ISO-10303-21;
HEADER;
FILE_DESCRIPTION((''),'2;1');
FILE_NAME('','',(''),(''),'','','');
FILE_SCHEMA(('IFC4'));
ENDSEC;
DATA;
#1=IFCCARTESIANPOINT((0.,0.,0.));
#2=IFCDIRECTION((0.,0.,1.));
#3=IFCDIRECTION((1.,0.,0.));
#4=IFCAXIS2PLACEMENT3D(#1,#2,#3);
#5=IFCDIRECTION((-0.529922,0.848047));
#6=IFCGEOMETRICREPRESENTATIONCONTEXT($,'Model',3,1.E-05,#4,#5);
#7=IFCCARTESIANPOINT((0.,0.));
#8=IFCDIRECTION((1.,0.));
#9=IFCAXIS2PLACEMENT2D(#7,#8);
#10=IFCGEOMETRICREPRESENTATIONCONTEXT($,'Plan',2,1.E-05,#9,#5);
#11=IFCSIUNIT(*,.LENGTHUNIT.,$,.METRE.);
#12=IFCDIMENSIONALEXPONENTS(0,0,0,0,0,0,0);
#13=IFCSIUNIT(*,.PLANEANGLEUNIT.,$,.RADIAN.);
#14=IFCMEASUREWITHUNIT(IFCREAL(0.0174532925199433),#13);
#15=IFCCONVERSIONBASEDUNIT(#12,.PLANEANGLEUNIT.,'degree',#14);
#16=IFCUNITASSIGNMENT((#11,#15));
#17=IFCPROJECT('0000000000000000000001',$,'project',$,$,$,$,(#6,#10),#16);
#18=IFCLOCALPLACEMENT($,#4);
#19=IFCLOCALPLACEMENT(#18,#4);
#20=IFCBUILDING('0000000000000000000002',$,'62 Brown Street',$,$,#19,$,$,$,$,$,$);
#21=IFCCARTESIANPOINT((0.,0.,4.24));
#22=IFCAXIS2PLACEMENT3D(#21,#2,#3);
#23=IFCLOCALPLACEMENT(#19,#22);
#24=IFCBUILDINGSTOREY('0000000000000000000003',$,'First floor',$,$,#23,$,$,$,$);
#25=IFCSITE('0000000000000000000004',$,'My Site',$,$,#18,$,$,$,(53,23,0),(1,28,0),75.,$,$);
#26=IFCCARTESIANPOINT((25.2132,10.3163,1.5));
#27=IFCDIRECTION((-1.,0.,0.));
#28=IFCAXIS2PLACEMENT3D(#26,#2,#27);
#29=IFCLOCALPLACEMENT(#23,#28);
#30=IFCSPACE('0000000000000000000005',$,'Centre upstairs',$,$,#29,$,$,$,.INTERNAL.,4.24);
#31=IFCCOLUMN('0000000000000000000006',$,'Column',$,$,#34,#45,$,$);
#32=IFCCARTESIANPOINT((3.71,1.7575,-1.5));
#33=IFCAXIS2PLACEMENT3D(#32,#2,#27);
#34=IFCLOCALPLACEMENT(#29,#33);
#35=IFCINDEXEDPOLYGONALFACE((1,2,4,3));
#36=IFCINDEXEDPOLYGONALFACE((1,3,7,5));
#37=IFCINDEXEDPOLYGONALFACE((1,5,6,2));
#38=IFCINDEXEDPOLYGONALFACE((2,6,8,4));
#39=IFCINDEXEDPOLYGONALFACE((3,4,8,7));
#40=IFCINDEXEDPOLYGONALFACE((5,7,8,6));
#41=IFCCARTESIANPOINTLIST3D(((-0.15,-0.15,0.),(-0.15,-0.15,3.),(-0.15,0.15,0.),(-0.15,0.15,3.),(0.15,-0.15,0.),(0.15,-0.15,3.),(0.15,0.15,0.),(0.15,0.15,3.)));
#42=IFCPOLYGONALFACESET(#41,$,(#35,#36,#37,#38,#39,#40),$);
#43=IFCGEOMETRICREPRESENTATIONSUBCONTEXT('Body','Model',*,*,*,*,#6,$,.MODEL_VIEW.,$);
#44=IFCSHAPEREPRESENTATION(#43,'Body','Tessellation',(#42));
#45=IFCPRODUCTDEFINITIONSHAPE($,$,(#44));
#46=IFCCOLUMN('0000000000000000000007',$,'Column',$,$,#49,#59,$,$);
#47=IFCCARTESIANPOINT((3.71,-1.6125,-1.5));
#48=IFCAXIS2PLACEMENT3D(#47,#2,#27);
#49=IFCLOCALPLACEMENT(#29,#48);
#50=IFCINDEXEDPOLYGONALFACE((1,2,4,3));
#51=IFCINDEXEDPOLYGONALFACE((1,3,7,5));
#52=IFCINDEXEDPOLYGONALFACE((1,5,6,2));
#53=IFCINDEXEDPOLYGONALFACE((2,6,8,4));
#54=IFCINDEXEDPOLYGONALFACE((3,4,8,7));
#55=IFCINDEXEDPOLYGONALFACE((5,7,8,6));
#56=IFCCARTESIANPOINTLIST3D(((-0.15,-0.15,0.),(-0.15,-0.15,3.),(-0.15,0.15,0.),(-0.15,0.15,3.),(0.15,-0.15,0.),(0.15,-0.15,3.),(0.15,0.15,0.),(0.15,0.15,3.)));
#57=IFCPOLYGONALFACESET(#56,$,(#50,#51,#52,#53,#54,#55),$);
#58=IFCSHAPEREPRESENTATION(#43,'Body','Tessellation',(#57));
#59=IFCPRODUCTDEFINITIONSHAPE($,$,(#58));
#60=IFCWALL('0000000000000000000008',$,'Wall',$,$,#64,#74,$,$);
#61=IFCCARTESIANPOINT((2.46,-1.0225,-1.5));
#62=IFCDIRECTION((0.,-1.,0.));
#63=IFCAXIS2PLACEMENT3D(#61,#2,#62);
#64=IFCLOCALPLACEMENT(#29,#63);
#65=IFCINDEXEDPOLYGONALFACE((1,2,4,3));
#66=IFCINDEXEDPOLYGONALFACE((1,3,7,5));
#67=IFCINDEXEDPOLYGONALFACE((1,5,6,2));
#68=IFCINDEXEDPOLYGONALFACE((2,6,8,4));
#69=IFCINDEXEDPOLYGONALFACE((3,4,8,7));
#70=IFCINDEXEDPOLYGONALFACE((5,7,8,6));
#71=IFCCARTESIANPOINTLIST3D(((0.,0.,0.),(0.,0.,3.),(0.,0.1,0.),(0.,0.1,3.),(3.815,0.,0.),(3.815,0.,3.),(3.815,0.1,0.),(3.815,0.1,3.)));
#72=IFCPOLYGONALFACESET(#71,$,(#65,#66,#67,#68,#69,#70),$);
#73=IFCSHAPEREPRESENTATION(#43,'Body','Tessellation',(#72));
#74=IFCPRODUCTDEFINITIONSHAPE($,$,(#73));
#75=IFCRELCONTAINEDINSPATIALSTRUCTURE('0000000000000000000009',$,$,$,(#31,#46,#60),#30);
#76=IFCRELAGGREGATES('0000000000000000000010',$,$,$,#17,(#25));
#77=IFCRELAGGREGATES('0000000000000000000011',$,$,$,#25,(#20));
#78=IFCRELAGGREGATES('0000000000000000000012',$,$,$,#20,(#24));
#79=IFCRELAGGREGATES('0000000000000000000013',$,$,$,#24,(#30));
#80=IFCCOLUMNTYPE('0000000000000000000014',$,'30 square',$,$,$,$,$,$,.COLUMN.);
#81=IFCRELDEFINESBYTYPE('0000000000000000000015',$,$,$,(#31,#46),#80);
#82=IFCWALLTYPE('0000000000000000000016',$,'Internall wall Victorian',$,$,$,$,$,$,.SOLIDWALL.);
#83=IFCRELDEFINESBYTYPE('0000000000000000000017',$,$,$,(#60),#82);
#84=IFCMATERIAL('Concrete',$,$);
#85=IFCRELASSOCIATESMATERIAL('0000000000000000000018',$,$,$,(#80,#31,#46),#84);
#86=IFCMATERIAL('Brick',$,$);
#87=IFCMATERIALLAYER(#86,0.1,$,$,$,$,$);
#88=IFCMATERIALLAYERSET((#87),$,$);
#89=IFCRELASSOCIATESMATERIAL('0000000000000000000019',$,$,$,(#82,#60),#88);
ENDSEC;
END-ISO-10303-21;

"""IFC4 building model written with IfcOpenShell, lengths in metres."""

from ifc_helpers import new_model, entity, si_unit, converted_unit, direction, frame, origin_with_axes, origin_2d_with_axis, place, context, subcontext, project, spatial, indexed_curve, rectangle, outline, extrude, material, layer, layer_set, layer_usage, material_profile, profile_set, profile_usage, type_object, element, save


model = new_model("IFC4")

# Units and contexts
model_context = context("Model", 3, precision=1e-05, world=origin_with_axes(), true_north=direction((-0.529922, 0.848047)))
plan_context = context("Plan", 2, precision=1e-05, world=origin_2d_with_axis(), true_north=direction((-0.529922, 0.848047)))
body_context = subcontext(model_context, "Body", "Model", "MODEL_VIEW")
ifc_project = project(units=[si_unit("LENGTHUNIT", "METRE"), converted_unit("PLANEANGLEUNIT", "degree", entity("IfcReal", 0.0174532925199433), si_unit("PLANEANGLEUNIT", "RADIAN"), dimensions=[0, 0, 0, 0, 0, 0, 0])], contexts=[model_context, plan_context])

# Site, building, storey, space
site_placement = place(None, origin_with_axes())
site = spatial("IfcSite", under=ifc_project, at=site_placement, Name="My Site", RefLatitude=(53, 23, 0), RefLongitude=(1, 28, 0), RefElevation=75.0)
building_placement = place(site_placement, origin_with_axes())
building = spatial("IfcBuilding", under=site, at=building_placement, Name="62 Brown Street")
storey_placement = place(building_placement, frame((0.0, 0.0, 4.24), z_axis=(0.0, 0.0, 1.0), x_axis=(1.0, 0.0, 0.0)))
storey = spatial("IfcBuildingStorey", under=building, at=storey_placement, Name="First floor")
space_1_placement = place(storey_placement, frame((25.2132, 10.3163, 1.5), z_axis=(0.0, 0.0, 1.0), x_axis=(-1.0, 0.0, 0.0)))
space_1 = spatial("IfcSpace", under=storey, at=space_1_placement, Name="Centre upstairs", PredefinedType="INTERNAL", ElevationWithFlooring=4.24)

# Columns
ifc_material_1 = material(Name="Concrete")
ifc_material_profile_1 = material_profile(ifc_material_1, rectangle(XDim=0.3, YDim=0.3))
ifc_profile_set_1 = profile_set([ifc_material_profile_1])
ifc_profile_usage_1 = profile_usage(ifc_profile_set_1, cardinal=5)
column_type = type_object("IfcColumnType", Name="30 square", PredefinedType="COLUMN", material=ifc_profile_set_1)
column_1_placement = place(space_1_placement, frame((3.71, 1.7575, -1.5), z_axis=(0.0, 0.0, 1.0), x_axis=(-1.0, 0.0, 0.0)))
element("IfcColumn", 1, at=column_1_placement, inside=space_1, type_object=column_type, material=ifc_profile_usage_1, Name="Column", context=body_context, shape_type="SweptSolid", body=[
    extrude(rectangle(XDim=0.3, YDim=0.3), origin_with_axes(), (0.0, 0.0, 1.0), 3.0),
])
ifc_profile_usage_2 = profile_usage(ifc_profile_set_1, cardinal=5)
column_2_placement = place(space_1_placement, frame((3.71, -1.6125, -1.5), z_axis=(0.0, 0.0, 1.0), x_axis=(-1.0, 0.0, 0.0)))
element("IfcColumn", 2, at=column_2_placement, inside=space_1, type_object=column_type, material=ifc_profile_usage_2, Name="Column", context=body_context, shape_type="SweptSolid", body=[
    extrude(rectangle(XDim=0.3, YDim=0.3), origin_with_axes(), (0.0, 0.0, 1.0), 3.0),
])

# Wall
ifc_material_2 = material(Name="Brick")
ifc_layer_1 = layer(ifc_material_2, 0.1)
ifc_layer_set_1 = layer_set([ifc_layer_1])
ifc_layer_usage_1 = layer_usage(ifc_layer_set_1, "AXIS2", "POSITIVE", 0.0)
wall_type_1 = type_object("IfcWallType", Name="Internall wall Victorian", PredefinedType="SOLIDWALL", material=ifc_layer_set_1)
wall_1_placement = place(space_1_placement, frame((2.46, -1.0225, -1.5), z_axis=(0.0, 0.0, 1.0), x_axis=(0.0, -1.0, 0.0)))
element("IfcWall", 3, at=wall_1_placement, inside=space_1, type_object=wall_type_1, material=ifc_layer_usage_1, Name="Wall", context=body_context, shape_type="SweptSolid", body=[
    extrude(outline(indexed_curve([(0.0, 0.0), (0.0, 0.1), (3.815, 0.1), (3.815, 0.0), (0.0, 0.0)], self_intersect=False)), origin_with_axes(), (0.0, 0.0, 1.0), 3.0),
])

save(model, "model.ifc")
